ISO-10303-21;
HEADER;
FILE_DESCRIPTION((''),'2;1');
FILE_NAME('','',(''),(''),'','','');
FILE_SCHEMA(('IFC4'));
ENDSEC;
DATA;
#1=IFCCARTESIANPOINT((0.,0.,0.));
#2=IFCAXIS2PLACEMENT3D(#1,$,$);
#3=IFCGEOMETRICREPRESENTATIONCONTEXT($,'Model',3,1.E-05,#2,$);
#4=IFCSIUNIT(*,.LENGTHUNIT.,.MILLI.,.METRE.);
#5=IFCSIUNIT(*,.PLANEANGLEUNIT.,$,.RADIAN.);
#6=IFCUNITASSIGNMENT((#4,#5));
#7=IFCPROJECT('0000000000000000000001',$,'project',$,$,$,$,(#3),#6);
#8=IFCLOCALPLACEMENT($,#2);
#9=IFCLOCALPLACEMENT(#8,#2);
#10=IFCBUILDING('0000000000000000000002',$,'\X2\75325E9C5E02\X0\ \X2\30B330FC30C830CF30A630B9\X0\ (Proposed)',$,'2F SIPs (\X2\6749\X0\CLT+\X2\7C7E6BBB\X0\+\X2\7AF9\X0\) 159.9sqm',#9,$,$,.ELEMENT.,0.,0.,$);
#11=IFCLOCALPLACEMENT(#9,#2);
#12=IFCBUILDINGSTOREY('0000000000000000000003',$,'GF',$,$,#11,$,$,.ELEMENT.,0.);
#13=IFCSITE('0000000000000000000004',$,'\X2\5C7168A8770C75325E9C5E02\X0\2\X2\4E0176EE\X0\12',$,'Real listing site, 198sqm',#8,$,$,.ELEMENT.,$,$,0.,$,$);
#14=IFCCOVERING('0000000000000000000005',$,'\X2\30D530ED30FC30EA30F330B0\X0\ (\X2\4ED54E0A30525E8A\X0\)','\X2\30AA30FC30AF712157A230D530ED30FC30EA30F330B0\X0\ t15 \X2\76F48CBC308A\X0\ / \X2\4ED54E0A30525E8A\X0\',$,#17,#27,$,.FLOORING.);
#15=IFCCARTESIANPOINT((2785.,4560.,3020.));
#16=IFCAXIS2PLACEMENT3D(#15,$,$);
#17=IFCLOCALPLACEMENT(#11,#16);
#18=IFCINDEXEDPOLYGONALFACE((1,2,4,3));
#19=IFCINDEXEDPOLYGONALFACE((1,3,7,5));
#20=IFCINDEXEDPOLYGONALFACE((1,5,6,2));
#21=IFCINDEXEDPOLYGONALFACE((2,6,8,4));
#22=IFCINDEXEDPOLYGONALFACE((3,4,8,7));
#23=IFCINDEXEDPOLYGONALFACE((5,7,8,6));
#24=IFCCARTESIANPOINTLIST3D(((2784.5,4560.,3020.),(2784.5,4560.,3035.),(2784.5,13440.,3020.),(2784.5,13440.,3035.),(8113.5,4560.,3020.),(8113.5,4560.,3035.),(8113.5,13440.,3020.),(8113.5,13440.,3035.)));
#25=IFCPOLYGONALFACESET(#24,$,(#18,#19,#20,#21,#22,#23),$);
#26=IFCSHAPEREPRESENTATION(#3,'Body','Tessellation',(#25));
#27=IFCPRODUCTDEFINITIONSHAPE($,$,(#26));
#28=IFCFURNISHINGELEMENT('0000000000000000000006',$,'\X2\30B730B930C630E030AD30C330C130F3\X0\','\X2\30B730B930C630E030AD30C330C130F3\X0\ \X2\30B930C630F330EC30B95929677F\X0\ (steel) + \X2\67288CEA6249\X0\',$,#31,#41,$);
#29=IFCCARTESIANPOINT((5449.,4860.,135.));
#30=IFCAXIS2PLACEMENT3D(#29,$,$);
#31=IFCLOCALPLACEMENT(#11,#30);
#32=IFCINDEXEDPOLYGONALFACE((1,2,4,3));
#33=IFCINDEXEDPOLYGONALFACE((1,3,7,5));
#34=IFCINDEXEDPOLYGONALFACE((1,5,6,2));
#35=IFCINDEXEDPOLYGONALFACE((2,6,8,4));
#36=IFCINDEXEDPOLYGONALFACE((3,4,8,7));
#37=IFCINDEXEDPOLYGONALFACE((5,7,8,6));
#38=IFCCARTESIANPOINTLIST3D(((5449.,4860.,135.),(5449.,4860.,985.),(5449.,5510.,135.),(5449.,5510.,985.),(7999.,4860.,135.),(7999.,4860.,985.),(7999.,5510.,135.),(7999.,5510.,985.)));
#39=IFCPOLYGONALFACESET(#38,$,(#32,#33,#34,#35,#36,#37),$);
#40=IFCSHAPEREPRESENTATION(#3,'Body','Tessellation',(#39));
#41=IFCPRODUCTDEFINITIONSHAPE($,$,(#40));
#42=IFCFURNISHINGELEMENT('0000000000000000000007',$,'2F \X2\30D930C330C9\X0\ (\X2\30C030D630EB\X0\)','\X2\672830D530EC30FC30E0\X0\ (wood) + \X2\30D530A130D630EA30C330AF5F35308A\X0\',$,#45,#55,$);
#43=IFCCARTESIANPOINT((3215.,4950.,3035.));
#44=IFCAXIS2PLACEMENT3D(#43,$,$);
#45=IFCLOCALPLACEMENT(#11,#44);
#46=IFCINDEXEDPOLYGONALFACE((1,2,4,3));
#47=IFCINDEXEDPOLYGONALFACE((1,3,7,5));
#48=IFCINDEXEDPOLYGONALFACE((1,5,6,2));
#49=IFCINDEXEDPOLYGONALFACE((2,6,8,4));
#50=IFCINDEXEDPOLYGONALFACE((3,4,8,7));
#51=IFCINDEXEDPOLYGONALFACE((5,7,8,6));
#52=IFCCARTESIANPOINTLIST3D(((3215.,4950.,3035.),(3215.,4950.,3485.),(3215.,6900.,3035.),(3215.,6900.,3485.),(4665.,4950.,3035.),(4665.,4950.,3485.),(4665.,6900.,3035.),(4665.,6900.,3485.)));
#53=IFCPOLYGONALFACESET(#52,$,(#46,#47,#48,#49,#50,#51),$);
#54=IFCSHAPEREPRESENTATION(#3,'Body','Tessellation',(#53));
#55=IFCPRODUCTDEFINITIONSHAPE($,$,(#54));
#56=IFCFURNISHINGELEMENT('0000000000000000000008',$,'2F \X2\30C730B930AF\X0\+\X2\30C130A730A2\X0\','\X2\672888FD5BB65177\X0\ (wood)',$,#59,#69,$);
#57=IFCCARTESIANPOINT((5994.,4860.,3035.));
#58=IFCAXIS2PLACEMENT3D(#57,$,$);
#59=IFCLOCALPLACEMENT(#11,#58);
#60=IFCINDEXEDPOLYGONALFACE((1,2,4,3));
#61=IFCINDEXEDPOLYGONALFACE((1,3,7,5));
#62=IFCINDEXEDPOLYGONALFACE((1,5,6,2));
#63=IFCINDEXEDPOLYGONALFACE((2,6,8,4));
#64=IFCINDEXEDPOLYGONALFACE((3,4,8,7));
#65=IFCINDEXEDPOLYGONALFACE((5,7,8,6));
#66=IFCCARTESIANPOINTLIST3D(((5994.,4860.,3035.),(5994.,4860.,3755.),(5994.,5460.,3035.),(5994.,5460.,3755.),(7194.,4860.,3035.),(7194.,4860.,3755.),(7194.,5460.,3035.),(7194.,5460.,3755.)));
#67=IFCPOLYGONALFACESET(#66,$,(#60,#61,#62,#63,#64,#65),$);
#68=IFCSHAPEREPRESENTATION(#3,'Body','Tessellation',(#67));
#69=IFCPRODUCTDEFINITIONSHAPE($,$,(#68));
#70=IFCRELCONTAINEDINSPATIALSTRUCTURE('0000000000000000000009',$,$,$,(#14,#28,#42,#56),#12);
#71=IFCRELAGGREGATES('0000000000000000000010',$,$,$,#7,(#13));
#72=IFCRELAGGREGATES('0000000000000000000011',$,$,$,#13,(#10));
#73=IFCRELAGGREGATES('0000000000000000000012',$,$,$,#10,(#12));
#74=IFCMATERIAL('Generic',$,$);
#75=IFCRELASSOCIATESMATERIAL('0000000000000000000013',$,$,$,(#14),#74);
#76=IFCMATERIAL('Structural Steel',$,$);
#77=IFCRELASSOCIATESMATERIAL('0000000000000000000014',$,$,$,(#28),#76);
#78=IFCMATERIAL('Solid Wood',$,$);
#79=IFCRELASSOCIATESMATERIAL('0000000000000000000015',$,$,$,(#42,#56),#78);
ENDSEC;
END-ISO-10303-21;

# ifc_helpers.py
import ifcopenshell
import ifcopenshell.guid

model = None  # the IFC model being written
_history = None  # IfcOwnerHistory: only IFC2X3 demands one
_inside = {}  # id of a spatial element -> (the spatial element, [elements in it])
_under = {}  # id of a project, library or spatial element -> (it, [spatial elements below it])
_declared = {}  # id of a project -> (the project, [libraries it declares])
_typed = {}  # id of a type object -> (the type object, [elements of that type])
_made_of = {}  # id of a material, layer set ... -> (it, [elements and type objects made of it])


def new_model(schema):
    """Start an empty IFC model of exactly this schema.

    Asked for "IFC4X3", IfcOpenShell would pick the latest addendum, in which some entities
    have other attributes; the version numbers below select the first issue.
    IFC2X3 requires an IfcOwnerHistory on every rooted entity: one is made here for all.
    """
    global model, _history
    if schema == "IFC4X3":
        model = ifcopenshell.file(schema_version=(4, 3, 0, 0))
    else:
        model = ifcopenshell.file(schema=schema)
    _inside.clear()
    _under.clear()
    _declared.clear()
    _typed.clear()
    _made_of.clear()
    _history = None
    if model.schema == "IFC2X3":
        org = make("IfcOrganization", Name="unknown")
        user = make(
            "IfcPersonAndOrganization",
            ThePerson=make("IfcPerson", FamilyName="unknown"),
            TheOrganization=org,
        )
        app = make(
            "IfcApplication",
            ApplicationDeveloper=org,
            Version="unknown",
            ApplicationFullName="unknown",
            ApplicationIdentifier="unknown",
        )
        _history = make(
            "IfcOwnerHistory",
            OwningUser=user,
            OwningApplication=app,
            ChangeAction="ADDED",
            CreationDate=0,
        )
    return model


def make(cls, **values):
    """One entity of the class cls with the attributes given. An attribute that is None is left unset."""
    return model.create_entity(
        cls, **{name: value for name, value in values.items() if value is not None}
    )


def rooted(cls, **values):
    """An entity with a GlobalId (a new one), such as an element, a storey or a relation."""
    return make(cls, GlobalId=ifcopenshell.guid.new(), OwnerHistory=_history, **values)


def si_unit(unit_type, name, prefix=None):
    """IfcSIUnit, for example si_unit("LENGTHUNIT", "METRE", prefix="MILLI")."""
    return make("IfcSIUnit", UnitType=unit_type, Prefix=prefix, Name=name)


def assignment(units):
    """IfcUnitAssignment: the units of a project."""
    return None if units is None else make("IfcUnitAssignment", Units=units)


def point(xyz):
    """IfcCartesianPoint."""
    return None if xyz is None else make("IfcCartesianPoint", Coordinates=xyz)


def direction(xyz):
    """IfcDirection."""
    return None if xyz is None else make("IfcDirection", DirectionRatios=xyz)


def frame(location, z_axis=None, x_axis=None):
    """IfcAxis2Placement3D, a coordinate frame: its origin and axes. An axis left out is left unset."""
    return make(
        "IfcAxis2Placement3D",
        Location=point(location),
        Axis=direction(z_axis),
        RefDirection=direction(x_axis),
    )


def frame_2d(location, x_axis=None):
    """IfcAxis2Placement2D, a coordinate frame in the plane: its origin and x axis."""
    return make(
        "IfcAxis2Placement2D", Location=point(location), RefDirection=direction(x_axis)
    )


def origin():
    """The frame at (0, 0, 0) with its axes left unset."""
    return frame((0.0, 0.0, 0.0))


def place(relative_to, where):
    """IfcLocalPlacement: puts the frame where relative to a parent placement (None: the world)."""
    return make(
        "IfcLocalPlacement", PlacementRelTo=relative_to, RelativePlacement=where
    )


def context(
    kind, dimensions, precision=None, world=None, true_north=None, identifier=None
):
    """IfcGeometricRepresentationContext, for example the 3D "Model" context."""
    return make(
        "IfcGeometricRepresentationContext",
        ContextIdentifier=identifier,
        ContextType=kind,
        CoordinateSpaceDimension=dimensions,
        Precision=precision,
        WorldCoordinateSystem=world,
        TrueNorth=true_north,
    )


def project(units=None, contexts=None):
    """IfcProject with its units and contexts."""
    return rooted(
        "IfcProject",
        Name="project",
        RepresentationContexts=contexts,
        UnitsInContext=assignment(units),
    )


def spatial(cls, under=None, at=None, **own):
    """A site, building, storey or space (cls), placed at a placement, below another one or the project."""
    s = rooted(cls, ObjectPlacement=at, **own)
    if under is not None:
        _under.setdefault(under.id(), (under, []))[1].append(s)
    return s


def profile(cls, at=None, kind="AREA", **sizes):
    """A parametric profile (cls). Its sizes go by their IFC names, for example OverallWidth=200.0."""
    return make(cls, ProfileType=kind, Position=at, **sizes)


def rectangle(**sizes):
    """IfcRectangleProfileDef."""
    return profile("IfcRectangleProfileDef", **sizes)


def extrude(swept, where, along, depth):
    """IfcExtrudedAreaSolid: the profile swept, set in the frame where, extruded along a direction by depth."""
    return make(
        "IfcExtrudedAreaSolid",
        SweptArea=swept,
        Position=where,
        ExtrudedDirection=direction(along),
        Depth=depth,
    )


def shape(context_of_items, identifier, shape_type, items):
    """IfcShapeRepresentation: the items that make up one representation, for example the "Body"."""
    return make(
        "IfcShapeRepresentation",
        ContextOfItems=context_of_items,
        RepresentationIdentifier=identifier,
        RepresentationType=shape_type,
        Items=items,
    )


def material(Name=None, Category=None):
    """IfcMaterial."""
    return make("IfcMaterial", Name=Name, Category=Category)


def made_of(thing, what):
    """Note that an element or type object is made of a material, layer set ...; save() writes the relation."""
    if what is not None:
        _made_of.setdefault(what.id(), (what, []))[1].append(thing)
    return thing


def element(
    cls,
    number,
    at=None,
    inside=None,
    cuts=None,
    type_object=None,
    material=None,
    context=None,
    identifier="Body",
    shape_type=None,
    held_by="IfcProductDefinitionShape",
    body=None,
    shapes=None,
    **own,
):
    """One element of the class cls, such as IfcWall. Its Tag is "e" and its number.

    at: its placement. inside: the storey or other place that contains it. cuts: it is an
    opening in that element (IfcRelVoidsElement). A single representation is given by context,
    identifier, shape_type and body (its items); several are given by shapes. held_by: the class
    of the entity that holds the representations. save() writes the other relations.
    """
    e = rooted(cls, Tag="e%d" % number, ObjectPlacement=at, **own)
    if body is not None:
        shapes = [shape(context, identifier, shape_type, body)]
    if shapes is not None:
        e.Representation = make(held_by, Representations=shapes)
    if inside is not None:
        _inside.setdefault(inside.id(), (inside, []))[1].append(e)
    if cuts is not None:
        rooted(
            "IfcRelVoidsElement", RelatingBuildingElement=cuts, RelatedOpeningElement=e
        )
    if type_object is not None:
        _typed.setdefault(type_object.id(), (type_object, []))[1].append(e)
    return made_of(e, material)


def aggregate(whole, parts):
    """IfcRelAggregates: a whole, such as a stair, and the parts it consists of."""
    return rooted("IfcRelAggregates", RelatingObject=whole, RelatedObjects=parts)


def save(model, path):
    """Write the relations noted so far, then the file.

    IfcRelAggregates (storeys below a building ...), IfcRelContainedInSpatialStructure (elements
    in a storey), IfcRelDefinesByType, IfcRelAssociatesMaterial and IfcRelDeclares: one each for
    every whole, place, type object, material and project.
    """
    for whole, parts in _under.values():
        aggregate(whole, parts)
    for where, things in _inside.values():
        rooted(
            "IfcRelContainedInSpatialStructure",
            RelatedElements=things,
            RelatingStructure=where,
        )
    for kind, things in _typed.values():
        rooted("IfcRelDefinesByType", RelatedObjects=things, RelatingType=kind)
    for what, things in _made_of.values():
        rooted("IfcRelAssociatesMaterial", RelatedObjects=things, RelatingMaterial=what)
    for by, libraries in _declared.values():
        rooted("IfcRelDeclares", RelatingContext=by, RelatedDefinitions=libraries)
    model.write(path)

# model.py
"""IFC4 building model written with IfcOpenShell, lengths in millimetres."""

from ifc_helpers import new_model, si_unit, frame, frame_2d, origin, place, context, project, spatial, rectangle, extrude, material, element, save


model = new_model("IFC4")

# Units and contexts
model_context = context("Model", 3, precision=1e-05, world=origin())
ifc_project = project(units=[si_unit("LENGTHUNIT", "METRE", prefix="MILLI"), si_unit("PLANEANGLEUNIT", "RADIAN")], contexts=[model_context])

# Site, building, storey
site_placement = place(None, origin())
site = spatial("IfcSite", under=ifc_project, at=site_placement, Name="山梨県甲府市2丁目12", ObjectType="Real listing site, 198sqm", CompositionType="ELEMENT", RefElevation=0.0)
building_placement = place(site_placement, origin())
building = spatial("IfcBuilding", under=site, at=building_placement, Name="甲府市 コートハウス (Proposed)", ObjectType="2F SIPs (杉CLT+籾殻+竹) 159.9sqm", CompositionType="ELEMENT", ElevationOfRefHeight=0.0, ElevationOfTerrain=0.0)
storey_placement = place(building_placement, origin())
storey = spatial("IfcBuildingStorey", under=building, at=storey_placement, Name="GF", CompositionType="ELEMENT", Elevation=0.0)

# Shared definitions
ifc_material_1 = material(Name="Solid Wood")

# Shared definitions
ifc_material_2 = material(Name="Generic")

# Shared definitions
ifc_material_3 = material(Name="Structural Steel")

# Covering
covering_placement = place(storey_placement, frame((2785.0, 4560.0, 3020.0)))
element("IfcCovering", 1, at=covering_placement, inside=storey, material=ifc_material_2, Name="フローリング (仕上げ床)", Description="オーク無垢フローリング t15 直貼り / 仕上げ床", PredefinedType="FLOORING", context=model_context, shape_type="SweptSolid", body=[
    extrude(rectangle(XDim=5329.0, YDim=8880.0, at=frame_2d((2664.0, 4440.0))), frame((2785.0, 4560.0, 3020.0)), (0.0, 0.0, 1.0), 15.0),
])

# Furnishing elements
furnishing_1_placement = place(storey_placement, frame((5449.0, 4860.0, 135.0)))
element("IfcFurnishingElement", 2, at=furnishing_1_placement, inside=storey, material=ifc_material_3, Name="システムキッチン", Description="システムキッチン ステンレス天板 (steel) + 木質扉", context=model_context, shape_type="SweptSolid", body=[
    extrude(rectangle(XDim=2550.0, YDim=650.0, at=frame_2d((1275.0, 325.0))), frame((5449.0, 4860.0, 135.0)), (0.0, 0.0, 1.0), 850.0),
])
furnishing_2_placement = place(storey_placement, frame((3215.0, 4950.0, 3035.0)))
element("IfcFurnishingElement", 3, at=furnishing_2_placement, inside=storey, material=ifc_material_1, Name="2F ベッド (ダブル)", Description="木フレーム (wood) + ファブリック張り", context=model_context, shape_type="SweptSolid", body=[
    extrude(rectangle(XDim=1450.0, YDim=1950.0, at=frame_2d((725.0, 975.0))), frame((3215.0, 4950.0, 3035.0)), (0.0, 0.0, 1.0), 450.0),
])
furnishing_3_placement = place(storey_placement, frame((5994.0, 4860.0, 3035.0)))
element("IfcFurnishingElement", 4, at=furnishing_3_placement, inside=storey, material=ifc_material_1, Name="2F デスク+チェア", Description="木製家具 (wood)", context=model_context, shape_type="SweptSolid", body=[
    extrude(rectangle(XDim=1200.0, YDim=600.0, at=frame_2d((600.0, 300.0))), frame((5994.0, 4860.0, 3035.0)), (0.0, 0.0, 1.0), 720.0),
])

save(model, "model.ifc")
